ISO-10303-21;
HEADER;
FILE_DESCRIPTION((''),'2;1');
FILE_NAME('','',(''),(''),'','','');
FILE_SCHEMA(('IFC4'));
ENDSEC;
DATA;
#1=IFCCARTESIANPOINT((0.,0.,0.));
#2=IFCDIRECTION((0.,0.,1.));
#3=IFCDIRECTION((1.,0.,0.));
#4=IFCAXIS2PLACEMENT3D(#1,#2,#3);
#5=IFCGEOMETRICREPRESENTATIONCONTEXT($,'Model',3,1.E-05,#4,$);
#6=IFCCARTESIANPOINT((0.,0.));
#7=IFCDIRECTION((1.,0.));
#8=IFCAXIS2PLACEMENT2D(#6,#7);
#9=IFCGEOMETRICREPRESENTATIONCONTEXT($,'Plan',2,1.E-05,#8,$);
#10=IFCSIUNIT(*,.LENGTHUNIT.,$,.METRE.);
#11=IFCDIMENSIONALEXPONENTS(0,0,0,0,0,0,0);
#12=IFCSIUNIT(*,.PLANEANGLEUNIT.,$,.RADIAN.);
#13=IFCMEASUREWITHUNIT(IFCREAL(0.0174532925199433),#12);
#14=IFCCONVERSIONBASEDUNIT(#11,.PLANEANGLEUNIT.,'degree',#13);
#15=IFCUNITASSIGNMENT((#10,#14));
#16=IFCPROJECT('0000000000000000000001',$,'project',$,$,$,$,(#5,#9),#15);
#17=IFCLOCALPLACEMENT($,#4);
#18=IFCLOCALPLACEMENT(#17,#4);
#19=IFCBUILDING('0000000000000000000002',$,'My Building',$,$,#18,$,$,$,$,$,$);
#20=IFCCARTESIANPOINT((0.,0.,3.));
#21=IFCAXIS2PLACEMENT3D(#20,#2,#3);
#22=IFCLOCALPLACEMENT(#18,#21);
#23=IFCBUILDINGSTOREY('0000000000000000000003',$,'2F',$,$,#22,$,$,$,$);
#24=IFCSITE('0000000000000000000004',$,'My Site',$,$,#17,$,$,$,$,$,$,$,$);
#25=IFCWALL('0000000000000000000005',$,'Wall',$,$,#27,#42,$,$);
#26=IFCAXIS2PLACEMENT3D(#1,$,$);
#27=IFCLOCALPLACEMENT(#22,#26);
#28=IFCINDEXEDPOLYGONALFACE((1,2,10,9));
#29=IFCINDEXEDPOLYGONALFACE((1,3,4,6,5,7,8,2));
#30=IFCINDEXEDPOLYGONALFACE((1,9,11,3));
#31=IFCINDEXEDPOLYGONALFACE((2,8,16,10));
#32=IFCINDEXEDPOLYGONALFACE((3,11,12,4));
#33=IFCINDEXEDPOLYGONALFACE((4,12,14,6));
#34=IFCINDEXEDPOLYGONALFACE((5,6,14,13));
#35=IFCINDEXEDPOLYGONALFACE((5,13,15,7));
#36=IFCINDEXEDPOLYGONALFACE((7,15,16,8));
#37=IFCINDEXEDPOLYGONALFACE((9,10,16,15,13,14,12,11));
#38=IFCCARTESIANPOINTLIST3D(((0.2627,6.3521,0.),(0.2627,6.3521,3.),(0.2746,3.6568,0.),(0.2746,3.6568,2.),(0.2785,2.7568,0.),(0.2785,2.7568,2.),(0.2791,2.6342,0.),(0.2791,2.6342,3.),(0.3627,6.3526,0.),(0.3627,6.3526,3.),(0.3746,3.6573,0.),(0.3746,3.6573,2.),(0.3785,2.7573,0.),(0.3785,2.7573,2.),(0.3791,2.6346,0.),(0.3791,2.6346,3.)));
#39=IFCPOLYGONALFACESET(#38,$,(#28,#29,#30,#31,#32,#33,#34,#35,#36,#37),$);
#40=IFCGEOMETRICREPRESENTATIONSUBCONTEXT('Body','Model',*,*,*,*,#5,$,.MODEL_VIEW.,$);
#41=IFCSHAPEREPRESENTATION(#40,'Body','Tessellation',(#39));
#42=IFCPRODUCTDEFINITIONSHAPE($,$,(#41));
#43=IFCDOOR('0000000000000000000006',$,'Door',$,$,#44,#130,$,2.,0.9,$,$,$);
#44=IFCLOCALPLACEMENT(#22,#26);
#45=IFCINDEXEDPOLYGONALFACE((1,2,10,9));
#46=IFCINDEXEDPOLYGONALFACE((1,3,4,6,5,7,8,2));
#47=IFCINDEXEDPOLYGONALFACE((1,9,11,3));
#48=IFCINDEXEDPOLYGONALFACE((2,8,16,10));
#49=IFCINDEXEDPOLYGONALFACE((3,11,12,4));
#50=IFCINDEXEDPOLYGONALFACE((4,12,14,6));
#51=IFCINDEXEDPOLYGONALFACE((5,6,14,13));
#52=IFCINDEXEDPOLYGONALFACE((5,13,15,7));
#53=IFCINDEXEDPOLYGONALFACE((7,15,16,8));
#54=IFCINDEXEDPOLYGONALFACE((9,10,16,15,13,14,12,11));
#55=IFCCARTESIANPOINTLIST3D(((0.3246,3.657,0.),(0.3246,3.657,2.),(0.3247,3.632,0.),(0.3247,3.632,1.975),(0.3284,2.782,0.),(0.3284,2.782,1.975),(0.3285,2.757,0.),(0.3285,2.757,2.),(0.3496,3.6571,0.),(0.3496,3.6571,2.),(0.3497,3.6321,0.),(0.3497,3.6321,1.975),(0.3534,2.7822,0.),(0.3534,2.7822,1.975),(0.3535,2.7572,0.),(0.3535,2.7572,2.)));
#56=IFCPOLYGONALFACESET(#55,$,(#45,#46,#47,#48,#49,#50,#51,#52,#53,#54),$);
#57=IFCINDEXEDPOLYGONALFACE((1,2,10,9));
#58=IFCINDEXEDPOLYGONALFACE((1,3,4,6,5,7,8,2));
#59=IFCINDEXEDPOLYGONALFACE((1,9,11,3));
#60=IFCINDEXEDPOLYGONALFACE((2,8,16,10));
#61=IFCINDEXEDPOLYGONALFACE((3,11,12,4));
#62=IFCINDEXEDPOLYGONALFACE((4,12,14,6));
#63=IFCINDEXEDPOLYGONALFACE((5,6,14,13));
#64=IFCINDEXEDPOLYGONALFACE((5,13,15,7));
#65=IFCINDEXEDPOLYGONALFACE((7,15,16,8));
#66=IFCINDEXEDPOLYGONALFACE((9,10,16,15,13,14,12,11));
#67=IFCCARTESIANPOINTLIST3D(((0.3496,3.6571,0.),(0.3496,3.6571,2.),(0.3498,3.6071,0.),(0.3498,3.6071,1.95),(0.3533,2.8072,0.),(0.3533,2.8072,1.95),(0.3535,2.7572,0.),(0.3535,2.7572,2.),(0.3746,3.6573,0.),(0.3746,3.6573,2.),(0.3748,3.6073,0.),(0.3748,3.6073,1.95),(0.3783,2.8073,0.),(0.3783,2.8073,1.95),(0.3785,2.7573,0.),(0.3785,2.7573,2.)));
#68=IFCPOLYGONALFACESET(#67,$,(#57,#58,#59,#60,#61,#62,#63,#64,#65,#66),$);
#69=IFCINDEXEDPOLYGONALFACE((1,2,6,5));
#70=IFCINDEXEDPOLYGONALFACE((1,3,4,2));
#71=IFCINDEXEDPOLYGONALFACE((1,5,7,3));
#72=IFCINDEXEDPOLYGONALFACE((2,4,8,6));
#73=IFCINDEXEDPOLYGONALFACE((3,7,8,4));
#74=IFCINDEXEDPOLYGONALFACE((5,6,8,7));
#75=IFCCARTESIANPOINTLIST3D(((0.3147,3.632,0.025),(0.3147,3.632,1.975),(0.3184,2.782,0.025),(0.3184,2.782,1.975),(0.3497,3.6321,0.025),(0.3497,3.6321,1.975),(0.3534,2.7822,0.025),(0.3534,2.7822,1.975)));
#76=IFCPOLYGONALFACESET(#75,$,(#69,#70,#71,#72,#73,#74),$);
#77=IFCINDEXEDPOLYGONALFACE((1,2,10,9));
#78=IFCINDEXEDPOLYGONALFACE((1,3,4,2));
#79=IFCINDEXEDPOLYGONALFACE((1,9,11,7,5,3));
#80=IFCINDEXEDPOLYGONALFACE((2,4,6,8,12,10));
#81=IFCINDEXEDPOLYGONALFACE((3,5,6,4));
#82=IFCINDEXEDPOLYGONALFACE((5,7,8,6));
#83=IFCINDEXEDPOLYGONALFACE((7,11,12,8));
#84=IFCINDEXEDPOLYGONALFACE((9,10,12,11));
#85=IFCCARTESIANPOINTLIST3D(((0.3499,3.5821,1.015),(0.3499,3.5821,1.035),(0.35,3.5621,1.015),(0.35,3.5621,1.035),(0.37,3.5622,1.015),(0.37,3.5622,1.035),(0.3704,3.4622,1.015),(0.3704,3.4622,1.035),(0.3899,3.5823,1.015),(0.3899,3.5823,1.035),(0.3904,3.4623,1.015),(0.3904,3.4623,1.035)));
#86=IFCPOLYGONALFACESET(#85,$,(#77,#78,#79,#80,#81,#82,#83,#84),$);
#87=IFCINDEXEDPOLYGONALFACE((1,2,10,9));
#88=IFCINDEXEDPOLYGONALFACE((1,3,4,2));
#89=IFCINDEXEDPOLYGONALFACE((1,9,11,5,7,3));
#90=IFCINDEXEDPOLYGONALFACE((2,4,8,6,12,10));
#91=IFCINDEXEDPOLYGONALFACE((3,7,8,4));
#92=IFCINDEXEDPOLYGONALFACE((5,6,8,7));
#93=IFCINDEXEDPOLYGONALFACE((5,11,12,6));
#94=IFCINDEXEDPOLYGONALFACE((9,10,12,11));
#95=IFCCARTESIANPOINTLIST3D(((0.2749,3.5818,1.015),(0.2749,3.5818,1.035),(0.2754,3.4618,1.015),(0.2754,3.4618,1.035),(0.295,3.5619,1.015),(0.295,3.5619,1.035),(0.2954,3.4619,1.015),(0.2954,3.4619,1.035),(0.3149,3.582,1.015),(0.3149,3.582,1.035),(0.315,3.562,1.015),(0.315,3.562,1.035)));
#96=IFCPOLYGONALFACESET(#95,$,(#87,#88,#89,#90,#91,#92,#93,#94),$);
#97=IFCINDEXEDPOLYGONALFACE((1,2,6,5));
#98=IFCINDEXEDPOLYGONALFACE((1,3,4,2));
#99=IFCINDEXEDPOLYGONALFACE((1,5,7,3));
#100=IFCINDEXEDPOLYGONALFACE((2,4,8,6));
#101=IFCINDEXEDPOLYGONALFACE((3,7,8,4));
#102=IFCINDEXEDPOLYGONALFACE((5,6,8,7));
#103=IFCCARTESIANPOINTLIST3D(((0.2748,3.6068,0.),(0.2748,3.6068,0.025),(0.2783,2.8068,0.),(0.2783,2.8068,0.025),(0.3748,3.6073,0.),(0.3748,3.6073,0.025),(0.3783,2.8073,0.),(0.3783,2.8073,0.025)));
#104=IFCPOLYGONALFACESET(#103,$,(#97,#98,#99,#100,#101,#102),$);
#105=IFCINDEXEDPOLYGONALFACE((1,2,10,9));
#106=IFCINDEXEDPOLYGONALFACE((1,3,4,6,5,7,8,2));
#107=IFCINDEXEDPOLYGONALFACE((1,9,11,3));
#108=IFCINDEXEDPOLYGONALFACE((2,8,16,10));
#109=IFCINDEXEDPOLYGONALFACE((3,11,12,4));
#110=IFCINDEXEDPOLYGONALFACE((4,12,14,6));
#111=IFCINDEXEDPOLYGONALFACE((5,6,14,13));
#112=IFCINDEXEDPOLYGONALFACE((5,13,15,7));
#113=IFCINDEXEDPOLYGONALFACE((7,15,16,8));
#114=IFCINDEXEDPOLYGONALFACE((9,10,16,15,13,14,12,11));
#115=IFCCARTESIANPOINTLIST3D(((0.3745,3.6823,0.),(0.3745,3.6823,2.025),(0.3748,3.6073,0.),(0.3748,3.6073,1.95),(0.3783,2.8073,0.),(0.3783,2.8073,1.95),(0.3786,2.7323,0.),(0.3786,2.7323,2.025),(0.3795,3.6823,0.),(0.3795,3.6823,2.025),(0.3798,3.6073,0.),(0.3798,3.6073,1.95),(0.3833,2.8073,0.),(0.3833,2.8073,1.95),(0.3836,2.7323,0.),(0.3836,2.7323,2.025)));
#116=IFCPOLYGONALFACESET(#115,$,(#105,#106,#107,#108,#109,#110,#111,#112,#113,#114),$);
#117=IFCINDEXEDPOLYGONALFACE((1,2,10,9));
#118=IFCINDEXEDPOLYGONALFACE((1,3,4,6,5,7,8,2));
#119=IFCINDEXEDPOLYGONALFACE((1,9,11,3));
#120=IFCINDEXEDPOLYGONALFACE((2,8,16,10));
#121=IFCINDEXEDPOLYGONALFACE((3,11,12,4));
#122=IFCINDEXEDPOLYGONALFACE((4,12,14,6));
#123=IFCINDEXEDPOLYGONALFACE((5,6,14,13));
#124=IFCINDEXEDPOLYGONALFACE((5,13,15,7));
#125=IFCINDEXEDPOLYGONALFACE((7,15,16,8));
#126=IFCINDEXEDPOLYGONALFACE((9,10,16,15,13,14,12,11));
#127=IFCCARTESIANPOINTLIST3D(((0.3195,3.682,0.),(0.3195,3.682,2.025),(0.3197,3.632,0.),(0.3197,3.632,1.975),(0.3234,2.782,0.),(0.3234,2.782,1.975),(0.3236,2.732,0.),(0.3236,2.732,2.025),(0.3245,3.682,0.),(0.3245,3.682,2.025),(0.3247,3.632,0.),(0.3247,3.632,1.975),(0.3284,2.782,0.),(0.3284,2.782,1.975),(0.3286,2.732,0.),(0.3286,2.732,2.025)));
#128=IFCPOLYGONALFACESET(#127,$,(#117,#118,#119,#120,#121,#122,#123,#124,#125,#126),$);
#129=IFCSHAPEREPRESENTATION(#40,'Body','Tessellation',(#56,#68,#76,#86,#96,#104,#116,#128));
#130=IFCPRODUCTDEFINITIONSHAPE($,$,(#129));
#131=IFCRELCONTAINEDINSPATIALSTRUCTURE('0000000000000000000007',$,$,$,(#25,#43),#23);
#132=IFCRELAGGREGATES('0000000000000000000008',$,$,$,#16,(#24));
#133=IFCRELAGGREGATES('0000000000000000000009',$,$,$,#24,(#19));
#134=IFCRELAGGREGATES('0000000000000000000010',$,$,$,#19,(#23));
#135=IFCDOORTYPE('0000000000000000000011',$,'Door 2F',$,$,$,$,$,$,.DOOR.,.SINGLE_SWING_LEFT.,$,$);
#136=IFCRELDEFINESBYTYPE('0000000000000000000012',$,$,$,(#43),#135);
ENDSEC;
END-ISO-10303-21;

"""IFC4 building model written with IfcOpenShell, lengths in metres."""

from ifc_helpers import new_model, entity, si_unit, converted_unit, frame, origin_with_axes, origin_2d_with_axis, place, context, subcontext, project, spatial, line, indexed_curve, outline, extrude, shape, source, transform, mapped, type_object, type_shapes, element, fill, save


model = new_model("IFC4")

# Units and contexts
model_context = context("Model", 3, precision=1e-05, world=origin_with_axes())
plan_context = context("Plan", 2, precision=1e-05, world=origin_2d_with_axis())
body_context_1 = subcontext(model_context, "Body", "Model", "MODEL_VIEW")
body_context_2 = subcontext(plan_context, "Body", "Plan", "PLAN_VIEW")
ifc_project = project(units=[si_unit("LENGTHUNIT", "METRE"), converted_unit("PLANEANGLEUNIT", "degree", entity("IfcReal", 0.0174532925199433), si_unit("PLANEANGLEUNIT", "RADIAN"), dimensions=[0, 0, 0, 0, 0, 0, 0])], contexts=[model_context, plan_context])

# Site, building, storey
site_placement = place(None, origin_with_axes())
site = spatial("IfcSite", under=ifc_project, at=site_placement, Name="My Site")
building_placement = place(site_placement, origin_with_axes())
building = spatial("IfcBuilding", under=site, at=building_placement, Name="My Building")
storey_placement = place(building_placement, frame((0.0, 0.0, 3.0), z_axis=(0.0, 0.0, 1.0), x_axis=(1.0, 0.0, 0.0)))
storey = spatial("IfcBuildingStorey", under=building, at=storey_placement, Name="2F")

# Shared definitions
shared_shape_1 = source(origin_with_axes(), body_context_1, "Body", "SweptSolid", [
    extrude(outline(indexed_curve([(0.0, 0.0), (0.9, 0.0), (0.9, 2.0), (0.0, 2.0)], segments=[line(1, 2, 3, 4, 1)])), frame((0.0, -0.6, 0.0), z_axis=(0.0, -1.0, 0.0), x_axis=(1.0, 0.0, 0.0)), (0.0, 0.0, -1.0), 1.2),
])
door_type = type_object("IfcDoorType", Name="Door 2F", OperationType="SINGLE_SWING_LEFT", PredefinedType="DOOR")
shared_shape_2 = source(origin_with_axes(), body_context_1, "Body", "SweptSolid", [
    extrude(outline(indexed_curve([(0.0, 0.0), (0.0, 2.0), (0.9, 2.0), (0.9, 0.0), (0.875, 0.0), (0.875, 1.975), (0.025, 1.975), (0.025, 0.0)], segments=[line(1, 2, 3, 4, 5, 6, 7, 8, 1)])), frame((0.0, 0.025, 0.0), z_axis=(0.0, -1.0, 0.0), x_axis=(1.0, 0.0, 0.0)), (0.0, 0.0, -1.0), 0.025),
    extrude(outline(indexed_curve([(0.0, 0.0), (0.0, 2.0), (0.9, 2.0), (0.9, 0.0), (0.85, 0.0), (0.85, 1.95), (0.05, 1.95), (0.05, 0.0)], segments=[line(1, 2, 3, 4, 5, 6, 7, 8, 1)])), frame((0.0, 0.0, 0.0), z_axis=(0.0, -1.0, 0.0), x_axis=(1.0, 0.0, 0.0)), (0.0, 0.0, -1.0), 0.025),
    extrude(outline(indexed_curve([(0.0, 0.0), (0.85, 0.0), (0.85, 0.035), (0.0, 0.035)], segments=[line(1, 2, 3, 4, 1)])), frame((0.025, 0.025, 0.025), z_axis=(0.0, 0.0, 1.0), x_axis=(1.0, 0.0, 0.0)), (0.0, 0.0, 1.0), 1.95),
    extrude(outline(indexed_curve([(0.0, 0.0), (0.0, -0.04), (-0.12, -0.04), (-0.12, -0.02), (-0.02, -0.02), (-0.02, 0.0)], segments=[line(1, 2, 3, 4, 5, 6, 1)])), frame((0.825, 0.025, 1.015), z_axis=(0.0, 0.0, 1.0), x_axis=(1.0, 0.0, 0.0)), (0.0, 0.0, 1.0), 0.02),
    extrude(outline(indexed_curve([(0.0, 0.0), (0.0, 0.04), (-0.12, 0.04), (-0.12, 0.02), (-0.02, 0.02), (-0.02, 0.0)], segments=[line(1, 2, 3, 4, 5, 6, 1)])), frame((0.825, 0.06, 1.015), z_axis=(0.0, 0.0, 1.0), x_axis=(1.0, 0.0, 0.0)), (0.0, 0.0, 1.0), 0.02),
    extrude(outline(indexed_curve([(0.0, 0.0), (0.8, 0.0), (0.8, 0.1), (0.0, 0.1)], segments=[line(1, 2, 3, 4, 1)])), frame((0.05, 0.0, 0.0), z_axis=(0.0, 0.0, 1.0), x_axis=(1.0, 0.0, 0.0)), (0.0, 0.0, 1.0), 0.025),
    extrude(outline(indexed_curve([(0.0, 0.0), (0.0, 2.025), (0.95, 2.025), (0.95, 0.0), (0.875, 0.0), (0.875, 1.95), (0.075, 1.95), (0.075, 0.0)], segments=[line(1, 2, 3, 4, 5, 6, 7, 8, 1)])), frame((-0.025, -0.005, 0.0), z_axis=(0.0, -1.0, 0.0), x_axis=(1.0, 0.0, 0.0)), (0.0, 0.0, -1.0), 0.005),
    extrude(outline(indexed_curve([(0.0, 0.0), (0.0, 2.025), (0.95, 2.025), (0.95, 0.0), (0.9, 0.0), (0.9, 1.975), (0.05, 1.975), (0.05, 0.0)], segments=[line(1, 2, 3, 4, 5, 6, 7, 8, 1)])), frame((-0.025, 0.05, 0.0), z_axis=(0.0, -1.0, 0.0), x_axis=(1.0, 0.0, 0.0)), (0.0, 0.0, -1.0), 0.005),
])
shared_shape_3 = source(origin_with_axes(), body_context_2, "Body", "Curve2D", [
    entity("IfcIndexedPolyCurve", entity("IfcCartesianPointList2D", [[0.0, 0.0], [0.0, 0.05], [0.025, 0.05], [0.025, 0.025], [0.05, 0.025], [0.05, 0.0]]), [entity("IfcLineIndex", [1, 2, 3, 4, 5, 6, 1])]),
    entity("IfcIndexedPolyCurve", entity("IfcCartesianPointList2D", [[0.9, 0.0], [0.9, 0.05], [0.875, 0.05], [0.875, 0.025], [0.85, 0.025], [0.85, 0.0]]), [entity("IfcLineIndex", [1, 2, 3, 4, 5, 6, 1])]),
    entity("IfcTrimmedCurve", entity("IfcEllipse", entity("IfcAxis2Placement2D", entity("IfcCartesianPoint", [0.06, 0.05]), entity("IfcDirection", [1.0, 0.0])), 0.815, 0.85), [entity("IfcCartesianPoint", [0.875, 0.05])], [entity("IfcCartesianPoint", [0.06, 0.9])], True, "CARTESIAN"),
    entity("IfcIndexedPolyCurve", entity("IfcCartesianPointList2D", [[0.025, 0.05], [0.06, 0.05], [0.06, 0.9], [0.025, 0.9]]), [entity("IfcLineIndex", [1, 2, 3, 4, 1])]),
])
type_shapes(door_type, [shared_shape_2, shared_shape_3])

# Wall, opening, door
wall_1_placement = place(storey_placement, frame((0.3791, 2.6346, 0.0), z_axis=(0.0, 0.0, 1.0), x_axis=(-0.004392, 0.99999, 0.0)))
wall_1 = element("IfcWall", 1, at=wall_1_placement, inside=storey, Name="Wall", context=body_context_1, shape_type="SweptSolid", body=[
    extrude(outline(indexed_curve([(0.0, 0.0), (0.0, 0.1), (3.718, 0.1), (3.718, 0.0)], segments=[line(1, 2, 3, 4, 1)])), origin_with_axes(), (0.0, 0.0, 1.0), 3.0),
])
opening_1_placement = place(wall_1_placement, frame((0.1227, 0.0, 0.0), z_axis=(0.0, 0.0, 1.0), x_axis=(1.0, 0.0, 0.0)))
opening_1 = element("IfcOpeningElement", 2, at=opening_1_placement, cuts=wall_1, PredefinedType="OPENING", context=body_context_1, shape_type="MappedRepresentation", body=[
    mapped(shared_shape_1, transform((0.0, 0.0, 0.0), x_axis=(1.0, 0.0, 0.0), y_axis=(0.0, 1.0, 0.0), z_axis=(0.0, 0.0, 1.0), scale=1.0)),
])
door_1_placement = place(opening_1_placement, origin_with_axes())
door_1 = element("IfcDoor", 3, at=door_1_placement, inside=storey, type_object=door_type, Name="Door", OverallHeight=2.0, OverallWidth=0.9, shapes=[
    shape(body_context_1, "Body", "MappedRepresentation", [mapped(shared_shape_2, transform((0.0, 0.0, 0.0), x_axis=(1.0, 0.0, 0.0), y_axis=(0.0, 1.0, 0.0), z_axis=(0.0, 0.0, 1.0), scale=1.0))]),
    shape(body_context_2, "Body", "MappedRepresentation", [mapped(shared_shape_3, transform((0.0, 0.0, 0.0), x_axis=(1.0, 0.0, 0.0), y_axis=(0.0, 1.0, 0.0), z_axis=(0.0, 0.0, 1.0), scale=1.0))]),
])
fill(opening_1, door_1)

save(model, "model.ifc")
